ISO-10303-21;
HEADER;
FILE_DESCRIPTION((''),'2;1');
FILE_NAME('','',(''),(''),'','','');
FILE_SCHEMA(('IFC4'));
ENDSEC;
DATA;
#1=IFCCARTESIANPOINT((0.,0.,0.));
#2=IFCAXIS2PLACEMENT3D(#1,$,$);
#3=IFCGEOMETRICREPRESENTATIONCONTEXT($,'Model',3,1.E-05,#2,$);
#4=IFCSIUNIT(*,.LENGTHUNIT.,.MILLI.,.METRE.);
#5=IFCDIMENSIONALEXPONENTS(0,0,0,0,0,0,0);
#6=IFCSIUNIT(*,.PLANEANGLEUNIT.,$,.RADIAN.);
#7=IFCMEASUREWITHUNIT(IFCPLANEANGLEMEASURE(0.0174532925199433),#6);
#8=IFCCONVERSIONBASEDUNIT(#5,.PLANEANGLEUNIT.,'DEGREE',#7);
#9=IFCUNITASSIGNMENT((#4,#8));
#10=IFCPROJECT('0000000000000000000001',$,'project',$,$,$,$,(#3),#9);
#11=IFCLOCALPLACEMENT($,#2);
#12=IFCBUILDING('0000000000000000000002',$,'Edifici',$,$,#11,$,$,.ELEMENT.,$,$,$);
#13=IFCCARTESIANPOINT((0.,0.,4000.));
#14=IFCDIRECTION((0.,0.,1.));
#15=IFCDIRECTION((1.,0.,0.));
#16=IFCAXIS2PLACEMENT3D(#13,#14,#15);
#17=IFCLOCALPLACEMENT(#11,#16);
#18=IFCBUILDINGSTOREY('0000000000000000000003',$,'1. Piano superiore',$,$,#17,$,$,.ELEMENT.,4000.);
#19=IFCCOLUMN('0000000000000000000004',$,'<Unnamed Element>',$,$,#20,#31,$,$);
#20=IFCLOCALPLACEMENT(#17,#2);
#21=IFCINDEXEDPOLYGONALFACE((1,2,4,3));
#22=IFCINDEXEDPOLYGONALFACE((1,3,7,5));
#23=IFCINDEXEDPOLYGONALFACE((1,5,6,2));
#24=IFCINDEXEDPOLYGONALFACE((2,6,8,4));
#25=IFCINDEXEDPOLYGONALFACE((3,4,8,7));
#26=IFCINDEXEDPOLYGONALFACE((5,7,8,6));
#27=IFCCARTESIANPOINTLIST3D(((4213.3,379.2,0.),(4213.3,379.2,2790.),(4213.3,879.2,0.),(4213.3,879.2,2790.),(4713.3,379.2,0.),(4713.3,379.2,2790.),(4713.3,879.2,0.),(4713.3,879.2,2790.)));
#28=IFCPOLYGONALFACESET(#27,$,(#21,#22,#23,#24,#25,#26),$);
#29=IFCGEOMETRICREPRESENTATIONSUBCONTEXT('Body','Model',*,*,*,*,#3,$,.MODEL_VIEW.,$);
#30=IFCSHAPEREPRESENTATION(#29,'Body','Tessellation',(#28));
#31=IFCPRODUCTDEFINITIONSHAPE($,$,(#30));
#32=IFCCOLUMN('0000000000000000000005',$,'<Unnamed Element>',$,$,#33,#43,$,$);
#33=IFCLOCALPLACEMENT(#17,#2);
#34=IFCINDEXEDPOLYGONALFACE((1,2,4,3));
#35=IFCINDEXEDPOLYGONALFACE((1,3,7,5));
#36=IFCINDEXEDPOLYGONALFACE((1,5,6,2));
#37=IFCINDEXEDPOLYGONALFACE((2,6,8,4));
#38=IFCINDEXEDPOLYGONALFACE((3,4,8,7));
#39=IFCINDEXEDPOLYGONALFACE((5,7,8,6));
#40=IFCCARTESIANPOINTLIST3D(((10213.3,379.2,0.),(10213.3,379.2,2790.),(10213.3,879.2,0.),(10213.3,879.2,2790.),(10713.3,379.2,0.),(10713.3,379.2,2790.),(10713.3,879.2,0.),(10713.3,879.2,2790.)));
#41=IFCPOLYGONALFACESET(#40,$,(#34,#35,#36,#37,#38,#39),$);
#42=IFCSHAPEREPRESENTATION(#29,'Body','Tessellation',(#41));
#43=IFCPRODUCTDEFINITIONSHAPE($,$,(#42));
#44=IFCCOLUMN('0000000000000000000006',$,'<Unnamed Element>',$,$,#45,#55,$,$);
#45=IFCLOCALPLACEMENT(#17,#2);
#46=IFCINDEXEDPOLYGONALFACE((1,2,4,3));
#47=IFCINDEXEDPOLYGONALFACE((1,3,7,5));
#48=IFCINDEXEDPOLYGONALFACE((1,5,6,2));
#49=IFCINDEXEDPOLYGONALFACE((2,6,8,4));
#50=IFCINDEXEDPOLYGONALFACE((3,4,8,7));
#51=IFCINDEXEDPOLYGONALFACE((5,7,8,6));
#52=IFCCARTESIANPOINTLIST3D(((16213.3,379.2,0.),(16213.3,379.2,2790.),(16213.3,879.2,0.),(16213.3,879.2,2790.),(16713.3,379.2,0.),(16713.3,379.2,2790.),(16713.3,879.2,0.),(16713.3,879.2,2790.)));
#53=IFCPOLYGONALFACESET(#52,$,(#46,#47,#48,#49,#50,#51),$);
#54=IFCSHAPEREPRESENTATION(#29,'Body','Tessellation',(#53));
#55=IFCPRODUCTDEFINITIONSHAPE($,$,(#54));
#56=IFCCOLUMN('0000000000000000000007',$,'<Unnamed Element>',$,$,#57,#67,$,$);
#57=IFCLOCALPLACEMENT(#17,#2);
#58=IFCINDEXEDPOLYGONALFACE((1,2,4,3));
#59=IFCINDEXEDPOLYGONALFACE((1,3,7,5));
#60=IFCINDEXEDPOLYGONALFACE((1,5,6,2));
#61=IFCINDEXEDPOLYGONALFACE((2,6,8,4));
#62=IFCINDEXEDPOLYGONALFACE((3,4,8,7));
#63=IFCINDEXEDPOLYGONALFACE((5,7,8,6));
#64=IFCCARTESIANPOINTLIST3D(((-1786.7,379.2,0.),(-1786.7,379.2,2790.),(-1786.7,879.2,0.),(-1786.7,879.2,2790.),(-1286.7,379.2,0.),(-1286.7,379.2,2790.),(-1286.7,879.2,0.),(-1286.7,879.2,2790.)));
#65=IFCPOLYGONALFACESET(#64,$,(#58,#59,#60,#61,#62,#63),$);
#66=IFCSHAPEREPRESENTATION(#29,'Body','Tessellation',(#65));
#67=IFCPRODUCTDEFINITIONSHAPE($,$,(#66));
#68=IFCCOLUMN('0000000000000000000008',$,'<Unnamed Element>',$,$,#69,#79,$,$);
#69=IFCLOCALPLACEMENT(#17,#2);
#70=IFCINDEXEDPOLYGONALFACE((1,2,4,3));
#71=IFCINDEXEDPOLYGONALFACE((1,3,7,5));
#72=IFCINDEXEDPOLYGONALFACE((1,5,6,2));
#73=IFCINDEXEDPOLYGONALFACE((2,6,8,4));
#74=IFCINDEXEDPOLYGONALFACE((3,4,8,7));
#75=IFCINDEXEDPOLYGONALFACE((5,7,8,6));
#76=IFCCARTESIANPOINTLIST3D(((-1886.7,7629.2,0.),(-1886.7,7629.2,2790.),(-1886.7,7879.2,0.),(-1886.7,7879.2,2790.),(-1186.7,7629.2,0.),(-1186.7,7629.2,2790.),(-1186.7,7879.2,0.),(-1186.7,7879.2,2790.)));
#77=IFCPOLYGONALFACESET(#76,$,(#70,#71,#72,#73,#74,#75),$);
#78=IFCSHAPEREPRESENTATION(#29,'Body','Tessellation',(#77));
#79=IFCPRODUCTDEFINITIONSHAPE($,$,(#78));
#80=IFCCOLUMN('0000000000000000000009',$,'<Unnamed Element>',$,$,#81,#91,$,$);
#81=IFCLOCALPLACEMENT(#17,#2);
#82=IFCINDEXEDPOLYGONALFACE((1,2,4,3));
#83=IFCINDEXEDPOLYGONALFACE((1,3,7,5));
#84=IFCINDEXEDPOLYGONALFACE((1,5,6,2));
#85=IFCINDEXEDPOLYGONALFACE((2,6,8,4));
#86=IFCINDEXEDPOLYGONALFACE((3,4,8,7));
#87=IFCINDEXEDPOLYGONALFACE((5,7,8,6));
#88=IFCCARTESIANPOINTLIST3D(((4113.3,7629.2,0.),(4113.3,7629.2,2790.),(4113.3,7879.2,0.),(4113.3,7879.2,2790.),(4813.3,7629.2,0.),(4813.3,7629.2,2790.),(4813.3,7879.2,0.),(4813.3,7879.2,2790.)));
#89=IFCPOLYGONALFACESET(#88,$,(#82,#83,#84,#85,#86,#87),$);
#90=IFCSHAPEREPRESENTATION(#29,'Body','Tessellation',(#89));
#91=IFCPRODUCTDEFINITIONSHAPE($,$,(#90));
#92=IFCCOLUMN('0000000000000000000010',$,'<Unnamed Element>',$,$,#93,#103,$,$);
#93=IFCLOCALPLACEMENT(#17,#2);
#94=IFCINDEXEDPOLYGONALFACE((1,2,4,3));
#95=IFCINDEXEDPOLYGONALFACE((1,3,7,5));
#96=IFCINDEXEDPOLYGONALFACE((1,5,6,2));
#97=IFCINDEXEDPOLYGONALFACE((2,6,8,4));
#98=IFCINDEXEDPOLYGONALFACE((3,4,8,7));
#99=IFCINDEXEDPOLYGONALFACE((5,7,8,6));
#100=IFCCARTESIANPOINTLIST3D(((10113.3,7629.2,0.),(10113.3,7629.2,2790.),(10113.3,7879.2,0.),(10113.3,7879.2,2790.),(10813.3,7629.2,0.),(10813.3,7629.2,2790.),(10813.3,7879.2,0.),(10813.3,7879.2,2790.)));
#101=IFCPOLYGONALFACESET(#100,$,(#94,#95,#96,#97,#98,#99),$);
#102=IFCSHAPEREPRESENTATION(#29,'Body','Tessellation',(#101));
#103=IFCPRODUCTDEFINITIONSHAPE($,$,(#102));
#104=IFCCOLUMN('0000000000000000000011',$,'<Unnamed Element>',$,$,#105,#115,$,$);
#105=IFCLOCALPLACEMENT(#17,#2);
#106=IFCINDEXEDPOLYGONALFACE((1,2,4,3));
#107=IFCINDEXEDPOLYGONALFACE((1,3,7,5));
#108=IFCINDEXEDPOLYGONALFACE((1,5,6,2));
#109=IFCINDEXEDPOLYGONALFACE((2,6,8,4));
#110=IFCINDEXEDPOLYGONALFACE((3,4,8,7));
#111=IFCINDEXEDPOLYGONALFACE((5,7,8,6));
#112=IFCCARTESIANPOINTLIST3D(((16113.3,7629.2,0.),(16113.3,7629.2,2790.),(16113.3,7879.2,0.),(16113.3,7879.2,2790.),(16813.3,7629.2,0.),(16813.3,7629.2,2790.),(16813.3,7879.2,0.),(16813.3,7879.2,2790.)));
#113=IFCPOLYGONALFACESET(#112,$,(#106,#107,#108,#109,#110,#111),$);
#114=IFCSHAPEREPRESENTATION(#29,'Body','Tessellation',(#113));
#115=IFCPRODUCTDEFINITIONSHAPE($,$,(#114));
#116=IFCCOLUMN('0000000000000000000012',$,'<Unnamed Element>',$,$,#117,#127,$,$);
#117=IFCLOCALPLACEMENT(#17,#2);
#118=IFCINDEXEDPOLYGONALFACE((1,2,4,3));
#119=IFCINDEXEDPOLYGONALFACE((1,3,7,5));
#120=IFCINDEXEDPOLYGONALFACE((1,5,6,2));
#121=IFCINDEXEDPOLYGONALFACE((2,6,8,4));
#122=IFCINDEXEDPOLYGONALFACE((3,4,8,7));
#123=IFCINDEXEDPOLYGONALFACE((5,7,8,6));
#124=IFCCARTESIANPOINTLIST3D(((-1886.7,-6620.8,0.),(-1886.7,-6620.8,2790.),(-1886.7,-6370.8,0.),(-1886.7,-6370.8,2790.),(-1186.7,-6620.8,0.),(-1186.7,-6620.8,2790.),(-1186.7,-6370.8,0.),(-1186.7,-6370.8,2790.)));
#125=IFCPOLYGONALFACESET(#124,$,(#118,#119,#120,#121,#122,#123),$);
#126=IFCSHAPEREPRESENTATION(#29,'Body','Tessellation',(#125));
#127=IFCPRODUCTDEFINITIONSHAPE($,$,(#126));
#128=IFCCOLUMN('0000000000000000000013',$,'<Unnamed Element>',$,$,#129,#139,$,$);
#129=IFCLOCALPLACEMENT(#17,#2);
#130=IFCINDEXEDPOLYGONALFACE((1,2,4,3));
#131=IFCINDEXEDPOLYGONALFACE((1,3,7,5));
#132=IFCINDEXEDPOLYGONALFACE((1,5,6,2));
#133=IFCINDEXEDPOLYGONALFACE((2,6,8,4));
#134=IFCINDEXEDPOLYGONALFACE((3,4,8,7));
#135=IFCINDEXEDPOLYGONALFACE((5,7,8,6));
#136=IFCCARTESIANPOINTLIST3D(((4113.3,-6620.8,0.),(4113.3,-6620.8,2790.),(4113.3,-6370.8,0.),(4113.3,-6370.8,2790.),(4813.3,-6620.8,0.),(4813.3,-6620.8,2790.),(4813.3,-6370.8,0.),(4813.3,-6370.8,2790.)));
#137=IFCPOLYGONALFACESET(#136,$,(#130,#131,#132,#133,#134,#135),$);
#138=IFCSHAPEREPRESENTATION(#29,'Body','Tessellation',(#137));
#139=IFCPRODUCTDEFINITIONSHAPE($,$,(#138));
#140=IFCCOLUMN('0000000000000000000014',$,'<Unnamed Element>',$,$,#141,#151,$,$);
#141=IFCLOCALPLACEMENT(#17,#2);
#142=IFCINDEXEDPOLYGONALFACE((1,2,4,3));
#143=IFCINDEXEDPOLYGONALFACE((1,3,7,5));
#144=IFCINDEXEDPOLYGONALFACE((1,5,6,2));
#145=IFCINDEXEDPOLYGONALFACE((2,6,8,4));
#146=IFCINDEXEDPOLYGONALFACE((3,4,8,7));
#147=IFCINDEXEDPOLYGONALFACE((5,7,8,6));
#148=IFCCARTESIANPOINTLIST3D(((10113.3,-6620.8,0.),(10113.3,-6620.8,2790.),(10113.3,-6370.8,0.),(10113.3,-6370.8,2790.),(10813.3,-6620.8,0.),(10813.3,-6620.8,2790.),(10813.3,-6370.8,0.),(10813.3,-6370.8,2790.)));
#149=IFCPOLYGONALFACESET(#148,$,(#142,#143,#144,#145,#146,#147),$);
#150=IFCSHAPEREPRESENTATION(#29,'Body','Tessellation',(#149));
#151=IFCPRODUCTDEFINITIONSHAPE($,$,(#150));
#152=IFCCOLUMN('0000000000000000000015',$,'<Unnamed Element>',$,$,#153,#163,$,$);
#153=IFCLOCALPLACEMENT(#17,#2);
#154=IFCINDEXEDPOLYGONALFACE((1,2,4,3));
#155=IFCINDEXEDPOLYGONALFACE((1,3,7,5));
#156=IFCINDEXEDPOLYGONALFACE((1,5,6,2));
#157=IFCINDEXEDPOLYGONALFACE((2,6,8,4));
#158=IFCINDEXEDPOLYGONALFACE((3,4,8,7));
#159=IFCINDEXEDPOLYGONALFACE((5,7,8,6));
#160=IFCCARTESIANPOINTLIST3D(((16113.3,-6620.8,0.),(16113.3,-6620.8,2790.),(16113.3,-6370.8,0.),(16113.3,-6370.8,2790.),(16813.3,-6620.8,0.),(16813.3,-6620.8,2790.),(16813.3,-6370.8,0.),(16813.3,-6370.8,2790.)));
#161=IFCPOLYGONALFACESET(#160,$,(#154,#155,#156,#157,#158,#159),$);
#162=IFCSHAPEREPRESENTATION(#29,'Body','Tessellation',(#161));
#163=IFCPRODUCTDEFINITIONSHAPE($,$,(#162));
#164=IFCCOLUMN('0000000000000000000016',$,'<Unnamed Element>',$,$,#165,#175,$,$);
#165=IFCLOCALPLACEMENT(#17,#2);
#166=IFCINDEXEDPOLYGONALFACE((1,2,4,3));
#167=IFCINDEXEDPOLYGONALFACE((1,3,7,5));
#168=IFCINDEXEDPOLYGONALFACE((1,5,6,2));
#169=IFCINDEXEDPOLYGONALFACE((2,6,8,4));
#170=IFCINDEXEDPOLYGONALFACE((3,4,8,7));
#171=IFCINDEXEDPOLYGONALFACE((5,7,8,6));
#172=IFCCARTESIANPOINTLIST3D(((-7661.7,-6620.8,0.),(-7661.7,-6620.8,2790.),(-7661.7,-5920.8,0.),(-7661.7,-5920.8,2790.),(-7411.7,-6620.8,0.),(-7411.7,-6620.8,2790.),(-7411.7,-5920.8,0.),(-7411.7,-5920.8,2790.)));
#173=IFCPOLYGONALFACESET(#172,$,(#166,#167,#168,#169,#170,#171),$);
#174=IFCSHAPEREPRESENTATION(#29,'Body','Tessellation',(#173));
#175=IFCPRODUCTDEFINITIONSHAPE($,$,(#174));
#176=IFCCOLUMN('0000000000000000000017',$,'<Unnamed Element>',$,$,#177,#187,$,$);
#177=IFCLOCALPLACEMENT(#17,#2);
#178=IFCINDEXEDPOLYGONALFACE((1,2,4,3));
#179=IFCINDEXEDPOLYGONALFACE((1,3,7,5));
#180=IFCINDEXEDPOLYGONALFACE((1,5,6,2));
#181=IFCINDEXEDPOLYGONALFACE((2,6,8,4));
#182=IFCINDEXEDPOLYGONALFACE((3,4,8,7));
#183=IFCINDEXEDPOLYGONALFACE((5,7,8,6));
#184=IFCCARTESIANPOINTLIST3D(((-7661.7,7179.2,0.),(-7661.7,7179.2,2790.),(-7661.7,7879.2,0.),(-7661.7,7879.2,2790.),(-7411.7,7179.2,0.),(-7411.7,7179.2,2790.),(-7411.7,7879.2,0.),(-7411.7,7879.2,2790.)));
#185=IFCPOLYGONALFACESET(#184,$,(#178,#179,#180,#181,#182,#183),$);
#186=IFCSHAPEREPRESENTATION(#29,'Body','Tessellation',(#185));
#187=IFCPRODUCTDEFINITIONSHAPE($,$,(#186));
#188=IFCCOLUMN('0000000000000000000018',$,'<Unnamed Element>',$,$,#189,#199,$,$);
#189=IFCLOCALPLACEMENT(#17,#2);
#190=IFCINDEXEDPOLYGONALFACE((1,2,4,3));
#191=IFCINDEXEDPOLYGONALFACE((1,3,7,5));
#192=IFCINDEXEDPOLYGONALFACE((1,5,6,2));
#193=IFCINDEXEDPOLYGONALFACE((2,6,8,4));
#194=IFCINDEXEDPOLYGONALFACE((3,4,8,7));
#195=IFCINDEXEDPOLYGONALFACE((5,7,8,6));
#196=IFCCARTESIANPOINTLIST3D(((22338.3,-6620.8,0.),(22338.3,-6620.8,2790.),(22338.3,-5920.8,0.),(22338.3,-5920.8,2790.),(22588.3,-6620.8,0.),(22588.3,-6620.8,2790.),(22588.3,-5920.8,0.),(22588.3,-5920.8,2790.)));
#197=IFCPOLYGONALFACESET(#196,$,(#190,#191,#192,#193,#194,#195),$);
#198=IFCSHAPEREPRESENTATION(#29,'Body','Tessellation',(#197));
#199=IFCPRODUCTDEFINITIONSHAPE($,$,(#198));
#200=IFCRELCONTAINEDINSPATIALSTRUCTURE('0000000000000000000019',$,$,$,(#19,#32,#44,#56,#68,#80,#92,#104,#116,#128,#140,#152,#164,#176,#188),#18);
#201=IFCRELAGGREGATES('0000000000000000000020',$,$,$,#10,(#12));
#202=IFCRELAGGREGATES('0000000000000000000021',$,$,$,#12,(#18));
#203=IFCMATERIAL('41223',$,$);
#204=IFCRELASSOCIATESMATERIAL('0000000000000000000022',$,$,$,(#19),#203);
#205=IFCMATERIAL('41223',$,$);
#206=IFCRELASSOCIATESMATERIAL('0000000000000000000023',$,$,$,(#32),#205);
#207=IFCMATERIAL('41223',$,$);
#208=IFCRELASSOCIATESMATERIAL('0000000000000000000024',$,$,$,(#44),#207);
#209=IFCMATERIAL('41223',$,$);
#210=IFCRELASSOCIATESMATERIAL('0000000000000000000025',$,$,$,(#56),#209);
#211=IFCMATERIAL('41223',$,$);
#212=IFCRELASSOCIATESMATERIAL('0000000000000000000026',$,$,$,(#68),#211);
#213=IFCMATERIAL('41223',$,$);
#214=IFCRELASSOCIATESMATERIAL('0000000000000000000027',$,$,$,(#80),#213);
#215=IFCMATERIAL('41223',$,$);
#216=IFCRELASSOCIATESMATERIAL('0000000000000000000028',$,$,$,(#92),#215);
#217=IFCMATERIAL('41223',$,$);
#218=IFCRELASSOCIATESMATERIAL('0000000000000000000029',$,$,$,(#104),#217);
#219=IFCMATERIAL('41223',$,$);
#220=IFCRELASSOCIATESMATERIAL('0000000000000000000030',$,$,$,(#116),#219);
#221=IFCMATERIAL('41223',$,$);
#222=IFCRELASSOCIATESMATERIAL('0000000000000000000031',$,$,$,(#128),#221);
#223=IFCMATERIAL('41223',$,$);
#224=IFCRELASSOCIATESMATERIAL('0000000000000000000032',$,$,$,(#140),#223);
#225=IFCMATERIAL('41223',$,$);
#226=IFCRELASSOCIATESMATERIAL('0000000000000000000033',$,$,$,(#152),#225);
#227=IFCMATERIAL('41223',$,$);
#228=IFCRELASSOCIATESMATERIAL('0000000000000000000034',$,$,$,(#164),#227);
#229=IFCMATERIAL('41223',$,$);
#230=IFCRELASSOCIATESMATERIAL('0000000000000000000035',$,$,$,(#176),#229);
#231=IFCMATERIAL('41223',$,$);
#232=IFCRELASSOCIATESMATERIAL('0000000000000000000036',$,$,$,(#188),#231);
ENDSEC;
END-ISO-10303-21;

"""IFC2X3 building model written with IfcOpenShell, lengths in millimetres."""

from ifc_helpers import new_model, entity, si_unit, converted_unit, frame, frame_2d, origin, origin_with_axes, place, context, subcontext, project, spatial, rectangle, extrude, material, element, save


model = new_model("IFC2X3")

# Units and contexts
model_context = context("Model", 3, precision=1e-05, world=origin())
body_context = subcontext(model_context, "Body", "Model", "MODEL_VIEW")
ifc_project = project(units=[si_unit("LENGTHUNIT", "METRE", prefix="MILLI"), converted_unit("PLANEANGLEUNIT", "DEGREE", entity("IfcPlaneAngleMeasure", 0.0174532925199433), si_unit("PLANEANGLEUNIT", "RADIAN"), dimensions=[0, 0, 0, 0, 0, 0, 0])], contexts=[model_context])

# Building, storey
building_placement = place(None, origin())
building = spatial("IfcBuilding", under=ifc_project, at=building_placement, Name="Edifici", CompositionType="ELEMENT")
storey_placement = place(building_placement, frame((0.0, 0.0, 4000.0), z_axis=(0.0, 0.0, 1.0), x_axis=(1.0, 0.0, 0.0)))
storey = spatial("IfcBuildingStorey", under=building, at=storey_placement, Name="1. Piano superiore", CompositionType="ELEMENT", Elevation=4000.0)

# Columns
ifc_material_1 = material(Name="41223")
column_1_placement = place(storey_placement, frame((4213.3, 379.2, 0.0), z_axis=(0.0, 0.0, 1.0), x_axis=(1.0, 0.0, 0.0)))
element("IfcColumn", 1, at=column_1_placement, inside=storey, material=ifc_material_1, Name="<Unnamed Element>", context=body_context, shape_type="SweptSolid", body=[
    extrude(rectangle(XDim=500.0, YDim=500.0, at=frame_2d((250.0, 250.0), x_axis=(1.0, 0.0))), origin_with_axes(), (0.0, 0.0, 1.0), 2790.0),
])
ifc_material_2 = material(Name="41223")
column_2_placement = place(storey_placement, frame((10213.3, 379.2, 0.0), z_axis=(0.0, 0.0, 1.0), x_axis=(1.0, 0.0, 0.0)))
element("IfcColumn", 2, at=column_2_placement, inside=storey, material=ifc_material_2, Name="<Unnamed Element>", context=body_context, shape_type="SweptSolid", body=[
    extrude(rectangle(XDim=500.0, YDim=500.0, at=frame_2d((250.0, 250.0), x_axis=(1.0, 0.0))), origin_with_axes(), (0.0, 0.0, 1.0), 2790.0),
])
ifc_material_3 = material(Name="41223")
column_3_placement = place(storey_placement, frame((16213.3, 379.2, 0.0), z_axis=(0.0, 0.0, 1.0), x_axis=(1.0, 0.0, 0.0)))
element("IfcColumn", 3, at=column_3_placement, inside=storey, material=ifc_material_3, Name="<Unnamed Element>", context=body_context, shape_type="SweptSolid", body=[
    extrude(rectangle(XDim=500.0, YDim=500.0, at=frame_2d((250.0, 250.0), x_axis=(1.0, 0.0))), origin_with_axes(), (0.0, 0.0, 1.0), 2790.0),
])
ifc_material_4 = material(Name="41223")
column_4_placement = place(storey_placement, frame((-1786.7, 379.2, 0.0), z_axis=(0.0, 0.0, 1.0), x_axis=(1.0, 0.0, 0.0)))
element("IfcColumn", 4, at=column_4_placement, inside=storey, material=ifc_material_4, Name="<Unnamed Element>", context=body_context, shape_type="SweptSolid", body=[
    extrude(rectangle(XDim=500.0, YDim=500.0, at=frame_2d((250.0, 250.0), x_axis=(1.0, 0.0))), origin_with_axes(), (0.0, 0.0, 1.0), 2790.0),
])
ifc_material_5 = material(Name="41223")
column_5_placement = place(storey_placement, frame((-1186.7, 7629.2, 0.0), z_axis=(0.0, 0.0, 1.0), x_axis=(1.0, 0.0, 0.0)))
element("IfcColumn", 5, at=column_5_placement, inside=storey, material=ifc_material_5, Name="<Unnamed Element>", context=body_context, shape_type="SweptSolid", body=[
    extrude(rectangle(XDim=250.0, YDim=700.0, at=frame_2d((-350.0, 125.0), x_axis=(0.0, 1.0))), origin_with_axes(), (0.0, 0.0, 1.0), 2790.0),
])
ifc_material_6 = material(Name="41223")
column_6_placement = place(storey_placement, frame((4813.3, 7629.2, 0.0), z_axis=(0.0, 0.0, 1.0), x_axis=(1.0, 0.0, 0.0)))
element("IfcColumn", 6, at=column_6_placement, inside=storey, material=ifc_material_6, Name="<Unnamed Element>", context=body_context, shape_type="SweptSolid", body=[
    extrude(rectangle(XDim=250.0, YDim=700.0, at=frame_2d((-350.0, 125.0), x_axis=(0.0, 1.0))), origin_with_axes(), (0.0, 0.0, 1.0), 2790.0),
])
ifc_material_7 = material(Name="41223")
column_7_placement = place(storey_placement, frame((10813.3, 7629.2, 0.0), z_axis=(0.0, 0.0, 1.0), x_axis=(1.0, 0.0, 0.0)))
element("IfcColumn", 7, at=column_7_placement, inside=storey, material=ifc_material_7, Name="<Unnamed Element>", context=body_context, shape_type="SweptSolid", body=[
    extrude(rectangle(XDim=250.0, YDim=700.0, at=frame_2d((-350.0, 125.0), x_axis=(0.0, 1.0))), origin_with_axes(), (0.0, 0.0, 1.0), 2790.0),
])
ifc_material_8 = material(Name="41223")
column_8_placement = place(storey_placement, frame((16813.3, 7629.2, 0.0), z_axis=(0.0, 0.0, 1.0), x_axis=(1.0, 0.0, 0.0)))
element("IfcColumn", 8, at=column_8_placement, inside=storey, material=ifc_material_8, Name="<Unnamed Element>", context=body_context, shape_type="SweptSolid", body=[
    extrude(rectangle(XDim=250.0, YDim=700.0, at=frame_2d((-350.0, 125.0), x_axis=(0.0, 1.0))), origin_with_axes(), (0.0, 0.0, 1.0), 2790.0),
])
ifc_material_9 = material(Name="41223")
column_9_placement = place(storey_placement, frame((-1186.7, -6620.8, 0.0), z_axis=(0.0, 0.0, 1.0), x_axis=(1.0, 0.0, 0.0)))
element("IfcColumn", 9, at=column_9_placement, inside=storey, material=ifc_material_9, Name="<Unnamed Element>", context=body_context, shape_type="SweptSolid", body=[
    extrude(rectangle(XDim=250.0, YDim=700.0, at=frame_2d((-350.0, 125.0), x_axis=(0.0, 1.0))), origin_with_axes(), (0.0, 0.0, 1.0), 2790.0),
])
ifc_material_10 = material(Name="41223")
column_10_placement = place(storey_placement, frame((4813.3, -6620.8, 0.0), z_axis=(0.0, 0.0, 1.0), x_axis=(1.0, 0.0, 0.0)))
element("IfcColumn", 10, at=column_10_placement, inside=storey, material=ifc_material_10, Name="<Unnamed Element>", context=body_context, shape_type="SweptSolid", body=[
    extrude(rectangle(XDim=250.0, YDim=700.0, at=frame_2d((-350.0, 125.0), x_axis=(0.0, 1.0))), origin_with_axes(), (0.0, 0.0, 1.0), 2790.0),
])
ifc_material_11 = material(Name="41223")
column_11_placement = place(storey_placement, frame((10813.3, -6620.8, 0.0), z_axis=(0.0, 0.0, 1.0), x_axis=(1.0, 0.0, 0.0)))
element("IfcColumn", 11, at=column_11_placement, inside=storey, material=ifc_material_11, Name="<Unnamed Element>", context=body_context, shape_type="SweptSolid", body=[
    extrude(rectangle(XDim=250.0, YDim=700.0, at=frame_2d((-350.0, 125.0), x_axis=(0.0, 1.0))), origin_with_axes(), (0.0, 0.0, 1.0), 2790.0),
])
ifc_material_12 = material(Name="41223")
column_12_placement = place(storey_placement, frame((16813.3, -6620.8, 0.0), z_axis=(0.0, 0.0, 1.0), x_axis=(1.0, 0.0, 0.0)))
element("IfcColumn", 12, at=column_12_placement, inside=storey, material=ifc_material_12, Name="<Unnamed Element>", context=body_context, shape_type="SweptSolid", body=[
    extrude(rectangle(XDim=250.0, YDim=700.0, at=frame_2d((-350.0, 125.0), x_axis=(0.0, 1.0))), origin_with_axes(), (0.0, 0.0, 1.0), 2790.0),
])
ifc_material_13 = material(Name="41223")
column_13_placement = place(storey_placement, frame((-7411.7, -5920.8, 0.0), z_axis=(0.0, 0.0, 1.0), x_axis=(1.0, 0.0, 0.0)))
element("IfcColumn", 13, at=column_13_placement, inside=storey, material=ifc_material_13, Name="<Unnamed Element>", context=body_context, shape_type="SweptSolid", body=[
    extrude(rectangle(XDim=250.0, YDim=700.0, at=frame_2d((-125.0, -350.0), x_axis=(-1.0, 0.0))), origin_with_axes(), (0.0, 0.0, 1.0), 2790.0),
])
ifc_material_14 = material(Name="41223")
column_14_placement = place(storey_placement, frame((-7411.7, 7879.2, 0.0), z_axis=(0.0, 0.0, 1.0), x_axis=(1.0, 0.0, 0.0)))
element("IfcColumn", 14, at=column_14_placement, inside=storey, material=ifc_material_14, Name="<Unnamed Element>", context=body_context, shape_type="SweptSolid", body=[
    extrude(rectangle(XDim=250.0, YDim=700.0, at=frame_2d((-125.0, -350.0), x_axis=(-1.0, 0.0))), origin_with_axes(), (0.0, 0.0, 1.0), 2790.0),
])
ifc_material_15 = material(Name="41223")
column_15_placement = place(storey_placement, frame((22588.3, -5920.8, 0.0), z_axis=(0.0, 0.0, 1.0), x_axis=(1.0, 0.0, 0.0)))
element("IfcColumn", 15, at=column_15_placement, inside=storey, material=ifc_material_15, Name="<Unnamed Element>", context=body_context, shape_type="SweptSolid", body=[
    extrude(rectangle(XDim=250.0, YDim=700.0, at=frame_2d((-125.0, -350.0), x_axis=(-1.0, 0.0))), origin_with_axes(), (0.0, 0.0, 1.0), 2790.0),
])

save(model, "model.ifc")
